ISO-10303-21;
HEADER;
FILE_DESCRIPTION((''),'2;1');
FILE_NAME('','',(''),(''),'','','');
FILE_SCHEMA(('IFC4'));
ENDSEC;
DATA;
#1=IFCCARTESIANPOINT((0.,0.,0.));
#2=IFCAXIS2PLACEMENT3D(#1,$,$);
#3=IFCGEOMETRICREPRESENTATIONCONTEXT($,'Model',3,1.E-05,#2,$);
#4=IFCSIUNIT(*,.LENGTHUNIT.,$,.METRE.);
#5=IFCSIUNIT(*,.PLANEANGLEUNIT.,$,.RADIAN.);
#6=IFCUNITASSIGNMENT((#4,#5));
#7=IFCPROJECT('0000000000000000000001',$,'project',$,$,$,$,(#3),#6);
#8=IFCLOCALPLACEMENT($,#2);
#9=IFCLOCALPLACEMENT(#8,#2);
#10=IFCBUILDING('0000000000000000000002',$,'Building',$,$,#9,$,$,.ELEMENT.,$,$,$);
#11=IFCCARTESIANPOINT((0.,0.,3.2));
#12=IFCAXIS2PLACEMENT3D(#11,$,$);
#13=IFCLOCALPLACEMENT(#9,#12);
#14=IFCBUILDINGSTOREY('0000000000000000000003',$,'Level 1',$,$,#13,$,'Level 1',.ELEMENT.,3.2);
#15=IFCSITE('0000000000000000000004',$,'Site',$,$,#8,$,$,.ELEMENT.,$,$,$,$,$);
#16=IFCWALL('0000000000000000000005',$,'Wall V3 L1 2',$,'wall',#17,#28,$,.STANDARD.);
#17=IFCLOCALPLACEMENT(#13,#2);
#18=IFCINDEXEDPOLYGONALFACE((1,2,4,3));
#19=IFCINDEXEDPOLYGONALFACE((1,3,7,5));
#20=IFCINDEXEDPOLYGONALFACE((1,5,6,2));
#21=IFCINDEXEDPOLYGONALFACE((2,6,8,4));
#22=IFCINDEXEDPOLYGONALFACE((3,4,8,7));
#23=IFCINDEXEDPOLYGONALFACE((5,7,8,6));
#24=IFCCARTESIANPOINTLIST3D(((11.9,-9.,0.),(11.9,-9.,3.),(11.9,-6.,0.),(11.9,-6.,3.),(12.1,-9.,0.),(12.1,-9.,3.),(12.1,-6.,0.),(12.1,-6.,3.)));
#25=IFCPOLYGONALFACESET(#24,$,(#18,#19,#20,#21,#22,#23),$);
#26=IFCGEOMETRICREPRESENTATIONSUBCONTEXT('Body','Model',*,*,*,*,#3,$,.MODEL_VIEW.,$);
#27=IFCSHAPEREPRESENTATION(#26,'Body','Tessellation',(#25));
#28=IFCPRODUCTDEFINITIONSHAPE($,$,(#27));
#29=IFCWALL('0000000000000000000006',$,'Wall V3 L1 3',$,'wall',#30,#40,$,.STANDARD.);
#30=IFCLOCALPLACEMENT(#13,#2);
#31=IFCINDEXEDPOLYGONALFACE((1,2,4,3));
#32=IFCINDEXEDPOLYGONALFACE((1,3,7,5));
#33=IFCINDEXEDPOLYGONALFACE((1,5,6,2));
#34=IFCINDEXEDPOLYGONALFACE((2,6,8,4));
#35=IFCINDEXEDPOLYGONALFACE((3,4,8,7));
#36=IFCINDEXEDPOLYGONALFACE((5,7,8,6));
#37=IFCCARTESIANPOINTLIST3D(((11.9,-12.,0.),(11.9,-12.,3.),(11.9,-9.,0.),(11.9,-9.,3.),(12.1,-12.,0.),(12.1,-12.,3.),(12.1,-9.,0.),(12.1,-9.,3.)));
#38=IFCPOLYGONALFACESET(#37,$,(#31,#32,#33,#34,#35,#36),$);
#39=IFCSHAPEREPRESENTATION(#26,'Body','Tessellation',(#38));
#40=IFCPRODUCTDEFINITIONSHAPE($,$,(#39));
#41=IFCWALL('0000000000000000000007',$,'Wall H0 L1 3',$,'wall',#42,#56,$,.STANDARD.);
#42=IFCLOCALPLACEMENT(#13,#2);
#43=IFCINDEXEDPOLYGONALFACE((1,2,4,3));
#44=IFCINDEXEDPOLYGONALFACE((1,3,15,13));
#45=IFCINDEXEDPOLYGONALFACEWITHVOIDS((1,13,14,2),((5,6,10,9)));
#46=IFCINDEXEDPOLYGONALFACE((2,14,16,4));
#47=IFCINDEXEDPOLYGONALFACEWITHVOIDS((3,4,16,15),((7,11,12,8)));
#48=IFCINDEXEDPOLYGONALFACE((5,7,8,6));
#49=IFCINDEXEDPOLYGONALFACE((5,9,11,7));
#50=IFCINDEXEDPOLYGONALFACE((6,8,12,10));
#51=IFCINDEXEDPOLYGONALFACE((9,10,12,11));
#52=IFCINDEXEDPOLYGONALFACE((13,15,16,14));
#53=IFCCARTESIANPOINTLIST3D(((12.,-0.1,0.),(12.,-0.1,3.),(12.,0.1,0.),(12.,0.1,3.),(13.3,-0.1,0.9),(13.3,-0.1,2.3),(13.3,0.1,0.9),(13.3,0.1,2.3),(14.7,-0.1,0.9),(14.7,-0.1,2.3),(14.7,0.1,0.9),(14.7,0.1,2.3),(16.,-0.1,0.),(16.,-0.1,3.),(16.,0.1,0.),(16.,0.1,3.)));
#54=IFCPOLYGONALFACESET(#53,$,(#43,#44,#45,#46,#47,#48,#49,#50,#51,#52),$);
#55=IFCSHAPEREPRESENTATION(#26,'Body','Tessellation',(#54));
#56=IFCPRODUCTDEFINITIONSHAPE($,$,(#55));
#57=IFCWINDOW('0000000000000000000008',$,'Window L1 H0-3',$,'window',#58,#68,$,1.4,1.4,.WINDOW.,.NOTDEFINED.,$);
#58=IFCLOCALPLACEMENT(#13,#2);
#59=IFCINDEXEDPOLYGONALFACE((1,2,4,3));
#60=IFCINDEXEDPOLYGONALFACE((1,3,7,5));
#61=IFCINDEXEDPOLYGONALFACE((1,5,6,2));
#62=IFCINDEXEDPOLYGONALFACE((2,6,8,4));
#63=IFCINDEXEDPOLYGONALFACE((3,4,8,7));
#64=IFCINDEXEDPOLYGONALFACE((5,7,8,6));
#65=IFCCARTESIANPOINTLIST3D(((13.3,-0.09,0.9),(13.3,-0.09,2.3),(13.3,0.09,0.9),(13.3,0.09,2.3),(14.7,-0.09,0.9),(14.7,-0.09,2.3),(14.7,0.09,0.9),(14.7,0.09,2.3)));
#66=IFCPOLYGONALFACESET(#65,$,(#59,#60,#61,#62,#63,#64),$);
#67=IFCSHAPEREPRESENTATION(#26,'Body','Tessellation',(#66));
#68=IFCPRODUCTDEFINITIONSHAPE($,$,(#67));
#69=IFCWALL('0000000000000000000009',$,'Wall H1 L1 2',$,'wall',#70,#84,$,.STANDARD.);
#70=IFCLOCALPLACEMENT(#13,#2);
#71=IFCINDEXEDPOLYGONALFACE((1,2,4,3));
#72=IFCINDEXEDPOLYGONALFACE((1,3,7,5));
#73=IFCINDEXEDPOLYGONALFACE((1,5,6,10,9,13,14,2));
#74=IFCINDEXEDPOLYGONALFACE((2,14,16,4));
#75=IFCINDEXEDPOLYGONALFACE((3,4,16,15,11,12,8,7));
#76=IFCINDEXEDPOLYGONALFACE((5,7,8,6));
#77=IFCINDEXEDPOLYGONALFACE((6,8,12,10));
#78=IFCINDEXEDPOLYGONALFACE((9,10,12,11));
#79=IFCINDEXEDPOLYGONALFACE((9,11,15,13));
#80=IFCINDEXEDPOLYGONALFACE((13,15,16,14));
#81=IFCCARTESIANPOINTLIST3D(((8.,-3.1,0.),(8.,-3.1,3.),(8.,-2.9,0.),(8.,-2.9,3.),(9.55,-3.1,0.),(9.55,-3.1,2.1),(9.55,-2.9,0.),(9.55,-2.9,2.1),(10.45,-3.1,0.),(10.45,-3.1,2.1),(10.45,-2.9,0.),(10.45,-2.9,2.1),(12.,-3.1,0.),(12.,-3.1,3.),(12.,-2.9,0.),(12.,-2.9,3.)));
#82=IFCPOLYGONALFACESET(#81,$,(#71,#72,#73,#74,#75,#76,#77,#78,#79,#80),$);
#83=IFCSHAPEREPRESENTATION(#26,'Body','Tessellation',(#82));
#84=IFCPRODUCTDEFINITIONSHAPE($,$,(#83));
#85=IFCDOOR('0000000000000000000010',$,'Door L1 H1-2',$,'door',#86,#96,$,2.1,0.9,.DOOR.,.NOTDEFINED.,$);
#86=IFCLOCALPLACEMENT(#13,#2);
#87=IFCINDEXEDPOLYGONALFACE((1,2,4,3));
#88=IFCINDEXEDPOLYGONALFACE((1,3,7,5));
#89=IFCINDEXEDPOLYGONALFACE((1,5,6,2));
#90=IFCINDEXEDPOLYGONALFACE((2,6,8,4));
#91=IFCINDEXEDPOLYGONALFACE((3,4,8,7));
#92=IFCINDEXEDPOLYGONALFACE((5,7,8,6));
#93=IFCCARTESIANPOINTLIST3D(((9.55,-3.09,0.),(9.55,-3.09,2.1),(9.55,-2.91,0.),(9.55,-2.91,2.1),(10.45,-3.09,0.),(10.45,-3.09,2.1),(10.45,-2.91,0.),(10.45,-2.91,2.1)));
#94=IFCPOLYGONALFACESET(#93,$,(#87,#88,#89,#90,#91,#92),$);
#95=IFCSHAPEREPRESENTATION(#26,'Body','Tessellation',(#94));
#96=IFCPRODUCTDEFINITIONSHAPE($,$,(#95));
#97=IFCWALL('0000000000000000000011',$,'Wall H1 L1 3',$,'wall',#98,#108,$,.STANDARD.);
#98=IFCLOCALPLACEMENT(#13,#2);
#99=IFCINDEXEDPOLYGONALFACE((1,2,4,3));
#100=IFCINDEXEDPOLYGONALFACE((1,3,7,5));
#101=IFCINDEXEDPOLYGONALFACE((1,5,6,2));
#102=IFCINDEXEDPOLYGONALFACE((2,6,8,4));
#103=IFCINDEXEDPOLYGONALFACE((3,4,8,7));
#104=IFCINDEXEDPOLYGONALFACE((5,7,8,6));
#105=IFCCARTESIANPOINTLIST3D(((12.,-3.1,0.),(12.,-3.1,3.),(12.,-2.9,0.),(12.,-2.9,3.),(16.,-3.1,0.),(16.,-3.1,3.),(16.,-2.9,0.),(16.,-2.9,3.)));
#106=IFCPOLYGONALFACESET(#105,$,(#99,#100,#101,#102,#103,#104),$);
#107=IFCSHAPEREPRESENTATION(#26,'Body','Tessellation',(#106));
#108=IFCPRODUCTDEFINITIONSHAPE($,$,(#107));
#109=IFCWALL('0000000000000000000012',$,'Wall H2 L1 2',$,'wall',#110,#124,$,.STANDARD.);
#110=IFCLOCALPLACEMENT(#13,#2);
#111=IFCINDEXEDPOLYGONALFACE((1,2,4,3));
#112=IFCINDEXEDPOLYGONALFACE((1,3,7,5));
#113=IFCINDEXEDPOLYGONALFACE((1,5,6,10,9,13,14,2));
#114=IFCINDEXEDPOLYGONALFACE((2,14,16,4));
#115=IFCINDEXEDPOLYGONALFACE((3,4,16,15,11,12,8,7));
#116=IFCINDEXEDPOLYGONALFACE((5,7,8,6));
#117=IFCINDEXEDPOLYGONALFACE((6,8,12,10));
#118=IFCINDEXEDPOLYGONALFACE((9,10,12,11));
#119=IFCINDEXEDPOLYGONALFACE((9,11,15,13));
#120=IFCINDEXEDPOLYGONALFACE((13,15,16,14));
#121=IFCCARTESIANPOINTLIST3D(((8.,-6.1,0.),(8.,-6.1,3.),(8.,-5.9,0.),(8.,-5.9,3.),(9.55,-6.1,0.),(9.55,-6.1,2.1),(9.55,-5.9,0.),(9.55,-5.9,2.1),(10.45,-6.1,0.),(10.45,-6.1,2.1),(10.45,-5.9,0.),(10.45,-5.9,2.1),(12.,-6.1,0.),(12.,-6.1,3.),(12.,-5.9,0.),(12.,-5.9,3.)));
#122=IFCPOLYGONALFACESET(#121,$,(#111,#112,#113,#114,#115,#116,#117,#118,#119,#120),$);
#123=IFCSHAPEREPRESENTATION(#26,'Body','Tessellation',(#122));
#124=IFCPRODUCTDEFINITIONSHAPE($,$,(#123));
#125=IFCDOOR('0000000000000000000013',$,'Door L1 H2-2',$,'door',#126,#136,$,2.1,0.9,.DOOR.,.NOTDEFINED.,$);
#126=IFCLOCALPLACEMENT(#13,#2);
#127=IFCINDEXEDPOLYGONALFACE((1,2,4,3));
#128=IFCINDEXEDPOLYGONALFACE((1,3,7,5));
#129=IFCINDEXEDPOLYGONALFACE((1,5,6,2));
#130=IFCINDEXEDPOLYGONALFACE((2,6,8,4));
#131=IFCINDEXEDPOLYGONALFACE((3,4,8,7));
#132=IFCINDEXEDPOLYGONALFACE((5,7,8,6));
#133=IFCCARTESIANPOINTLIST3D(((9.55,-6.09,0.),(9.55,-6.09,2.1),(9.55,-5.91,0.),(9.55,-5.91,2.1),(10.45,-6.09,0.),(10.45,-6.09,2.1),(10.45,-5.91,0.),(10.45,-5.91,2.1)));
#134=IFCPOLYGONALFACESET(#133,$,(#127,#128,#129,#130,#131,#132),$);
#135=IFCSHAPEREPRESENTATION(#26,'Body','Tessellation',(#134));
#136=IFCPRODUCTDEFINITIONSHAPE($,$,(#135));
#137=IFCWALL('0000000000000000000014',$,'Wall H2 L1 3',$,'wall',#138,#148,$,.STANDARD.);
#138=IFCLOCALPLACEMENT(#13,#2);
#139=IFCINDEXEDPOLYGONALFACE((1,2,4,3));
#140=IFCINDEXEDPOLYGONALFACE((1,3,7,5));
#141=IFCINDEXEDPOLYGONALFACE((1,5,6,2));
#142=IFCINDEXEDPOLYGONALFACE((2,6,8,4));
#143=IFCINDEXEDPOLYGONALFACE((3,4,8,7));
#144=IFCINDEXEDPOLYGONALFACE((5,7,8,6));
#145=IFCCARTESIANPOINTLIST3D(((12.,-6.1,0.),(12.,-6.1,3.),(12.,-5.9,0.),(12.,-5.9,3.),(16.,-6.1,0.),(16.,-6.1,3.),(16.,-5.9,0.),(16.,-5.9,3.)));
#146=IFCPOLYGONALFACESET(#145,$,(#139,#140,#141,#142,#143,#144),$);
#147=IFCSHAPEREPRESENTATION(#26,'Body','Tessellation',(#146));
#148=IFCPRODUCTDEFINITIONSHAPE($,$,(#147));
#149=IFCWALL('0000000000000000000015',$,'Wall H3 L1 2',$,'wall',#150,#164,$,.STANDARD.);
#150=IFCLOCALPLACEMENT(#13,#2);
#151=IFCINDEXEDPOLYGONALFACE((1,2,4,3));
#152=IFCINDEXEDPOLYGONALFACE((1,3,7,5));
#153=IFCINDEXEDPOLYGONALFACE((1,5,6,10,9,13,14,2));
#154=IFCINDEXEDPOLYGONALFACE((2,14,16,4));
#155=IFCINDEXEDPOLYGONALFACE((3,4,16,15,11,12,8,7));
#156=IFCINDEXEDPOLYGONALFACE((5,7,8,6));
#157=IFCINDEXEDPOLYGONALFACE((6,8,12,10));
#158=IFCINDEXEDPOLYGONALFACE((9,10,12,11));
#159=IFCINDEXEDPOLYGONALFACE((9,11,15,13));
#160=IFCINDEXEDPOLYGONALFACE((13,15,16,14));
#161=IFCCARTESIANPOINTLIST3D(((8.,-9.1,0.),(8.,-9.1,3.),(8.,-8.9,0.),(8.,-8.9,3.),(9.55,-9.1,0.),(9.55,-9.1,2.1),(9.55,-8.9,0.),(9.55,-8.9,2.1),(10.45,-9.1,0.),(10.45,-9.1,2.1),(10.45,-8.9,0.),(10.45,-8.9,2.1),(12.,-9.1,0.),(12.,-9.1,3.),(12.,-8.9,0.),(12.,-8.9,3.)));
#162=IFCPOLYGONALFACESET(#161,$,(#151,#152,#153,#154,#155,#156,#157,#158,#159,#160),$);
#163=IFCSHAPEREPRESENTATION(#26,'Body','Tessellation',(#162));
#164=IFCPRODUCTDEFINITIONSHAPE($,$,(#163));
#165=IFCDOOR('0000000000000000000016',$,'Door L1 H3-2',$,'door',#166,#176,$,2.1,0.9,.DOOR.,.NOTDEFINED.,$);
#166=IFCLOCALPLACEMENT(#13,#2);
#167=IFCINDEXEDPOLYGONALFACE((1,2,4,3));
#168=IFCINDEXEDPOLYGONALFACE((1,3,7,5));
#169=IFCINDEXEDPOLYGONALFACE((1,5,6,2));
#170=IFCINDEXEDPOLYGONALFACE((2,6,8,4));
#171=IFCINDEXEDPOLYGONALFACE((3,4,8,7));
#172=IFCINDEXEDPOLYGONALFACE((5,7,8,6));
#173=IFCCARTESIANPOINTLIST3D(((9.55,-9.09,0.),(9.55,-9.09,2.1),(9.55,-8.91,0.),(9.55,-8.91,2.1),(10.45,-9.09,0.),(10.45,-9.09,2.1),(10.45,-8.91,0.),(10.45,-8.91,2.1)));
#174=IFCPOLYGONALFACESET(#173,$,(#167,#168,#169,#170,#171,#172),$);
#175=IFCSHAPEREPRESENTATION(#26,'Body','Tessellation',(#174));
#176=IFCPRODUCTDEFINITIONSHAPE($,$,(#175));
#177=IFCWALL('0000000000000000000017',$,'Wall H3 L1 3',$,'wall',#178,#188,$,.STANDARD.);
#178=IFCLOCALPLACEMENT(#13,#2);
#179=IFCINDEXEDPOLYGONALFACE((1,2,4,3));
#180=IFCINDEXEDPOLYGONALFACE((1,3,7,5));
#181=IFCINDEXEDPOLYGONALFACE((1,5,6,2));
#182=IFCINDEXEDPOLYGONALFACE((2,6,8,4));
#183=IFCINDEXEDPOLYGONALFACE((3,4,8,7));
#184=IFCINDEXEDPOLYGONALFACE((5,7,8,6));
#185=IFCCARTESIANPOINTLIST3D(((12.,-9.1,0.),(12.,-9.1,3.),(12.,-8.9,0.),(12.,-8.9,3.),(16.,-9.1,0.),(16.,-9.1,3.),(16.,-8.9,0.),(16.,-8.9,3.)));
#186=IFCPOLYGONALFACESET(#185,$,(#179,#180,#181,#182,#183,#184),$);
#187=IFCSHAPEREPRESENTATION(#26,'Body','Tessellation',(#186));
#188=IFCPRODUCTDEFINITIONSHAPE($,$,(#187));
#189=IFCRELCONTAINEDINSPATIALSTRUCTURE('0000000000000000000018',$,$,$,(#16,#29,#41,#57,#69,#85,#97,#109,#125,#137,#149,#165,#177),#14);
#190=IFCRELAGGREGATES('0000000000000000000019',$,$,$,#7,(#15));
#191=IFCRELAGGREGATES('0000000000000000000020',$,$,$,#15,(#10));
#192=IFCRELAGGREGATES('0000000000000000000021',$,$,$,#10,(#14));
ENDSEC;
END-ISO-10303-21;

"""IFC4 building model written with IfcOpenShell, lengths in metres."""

from ifc_helpers import new_model, si_unit, frame, frame_2d, origin, origin_2d, place, context, subcontext, project, spatial, rectangle, extrude, element, fill, save


model = new_model("IFC4")

# Units and contexts
model_context = context("Model", 3, precision=1e-05, world=origin())
body_context = subcontext(model_context, "Body", "Model", "MODEL_VIEW")
ifc_project = project(units=[si_unit("LENGTHUNIT", "METRE"), si_unit("PLANEANGLEUNIT", "RADIAN")], contexts=[model_context])

# Site, building, storey
site_placement = place(None, origin())
site = spatial("IfcSite", under=ifc_project, at=site_placement, Name="Site", CompositionType="ELEMENT")
building_placement = place(site_placement, origin())
building = spatial("IfcBuilding", under=site, at=building_placement, Name="Building", CompositionType="ELEMENT")
storey_placement = place(building_placement, frame((0.0, 0.0, 3.2)))
storey = spatial("IfcBuildingStorey", under=building, at=storey_placement, Name="Level 1", LongName="Level 1", CompositionType="ELEMENT", Elevation=3.2)

# Walls
for number, where, z_axis, x_axis, name in (
    (1, (12.0, -6.0, 0.0), (0.0, 0.0, 1.0), (0.0, -1.0, 0.0), "Wall V3 L1 2"),
    (2, (12.0, -9.0, 0.0), (0.0, 0.0, 1.0), (0.0, -1.0, 0.0), "Wall V3 L1 3"),
):
    element("IfcWall", number, at=place(storey_placement, frame(where, z_axis=z_axis, x_axis=x_axis)), inside=storey, Name=name, ObjectType="wall", PredefinedType="STANDARD", context=body_context, shape_type="SweptSolid", body=[
        extrude(rectangle(XDim=3.0, YDim=0.2, at=frame_2d((1.5, 0.0))), origin(), (0.0, 0.0, 1.0), 3.0),
    ])

# Wall, opening, window
wall_1_placement = place(storey_placement, frame((12.0, 0.0, 0.0), z_axis=(0.0, 0.0, 1.0), x_axis=(1.0, 0.0, 0.0)))
wall_1 = element("IfcWall", 3, at=wall_1_placement, inside=storey, Name="Wall H0 L1 3", ObjectType="wall", PredefinedType="STANDARD", context=body_context, shape_type="SweptSolid", body=[
    extrude(rectangle(XDim=4.0, YDim=0.2, at=frame_2d((2.0, 0.0))), origin(), (0.0, 0.0, 1.0), 3.0),
])
opening_1_placement = place(storey_placement, frame((14.0, 0.0, 0.9), z_axis=(0.0, 0.0, 1.0), x_axis=(1.0, 0.0, 0.0)))
opening_1 = element("IfcOpeningElement", 4, at=opening_1_placement, cuts=wall_1, ObjectType="Opening", PredefinedType="OPENING", context=body_context, shape_type="SweptSolid", body=[
    extrude(rectangle(XDim=1.4, YDim=0.22, at=origin_2d()), origin(), (0.0, 0.0, 1.0), 1.4),
])
window_1_placement = place(storey_placement, frame((14.0, 0.0, 0.9), z_axis=(0.0, 0.0, 1.0), x_axis=(1.0, 0.0, 0.0)))
window_1 = element("IfcWindow", 5, at=window_1_placement, inside=storey, Name="Window L1 H0-3", ObjectType="window", OverallHeight=1.4, OverallWidth=1.4, PartitioningType="NOTDEFINED", PredefinedType="WINDOW", context=body_context, shape_type="SweptSolid", body=[
    extrude(rectangle(XDim=1.4, YDim=0.18, at=origin_2d()), origin(), (0.0, 0.0, 1.0), 1.4),
])
fill(opening_1, window_1)

# Wall, opening, door
wall_2_placement = place(storey_placement, frame((8.0, -3.0, 0.0), z_axis=(0.0, 0.0, 1.0), x_axis=(1.0, 0.0, 0.0)))
wall_2 = element("IfcWall", 6, at=wall_2_placement, inside=storey, Name="Wall H1 L1 2", ObjectType="wall", PredefinedType="STANDARD", context=body_context, shape_type="SweptSolid", body=[
    extrude(rectangle(XDim=4.0, YDim=0.2, at=frame_2d((2.0, 0.0))), origin(), (0.0, 0.0, 1.0), 3.0),
])
opening_2_placement = place(storey_placement, frame((10.0, -3.0, 0.0), z_axis=(0.0, 0.0, 1.0), x_axis=(1.0, 0.0, 0.0)))
opening_2 = element("IfcOpeningElement", 7, at=opening_2_placement, cuts=wall_2, ObjectType="Opening", PredefinedType="OPENING", context=body_context, shape_type="SweptSolid", body=[
    extrude(rectangle(XDim=0.9, YDim=0.22, at=origin_2d()), origin(), (0.0, 0.0, 1.0), 2.1),
])
door_1_placement = place(storey_placement, frame((10.0, -3.0, 0.0), z_axis=(0.0, 0.0, 1.0), x_axis=(1.0, 0.0, 0.0)))
door_1 = element("IfcDoor", 8, at=door_1_placement, inside=storey, Name="Door L1 H1-2", ObjectType="door", OperationType="NOTDEFINED", OverallHeight=2.1, OverallWidth=0.9, PredefinedType="DOOR", context=body_context, shape_type="SweptSolid", body=[
    extrude(rectangle(XDim=0.9, YDim=0.18, at=origin_2d()), origin(), (0.0, 0.0, 1.0), 2.1),
])
fill(opening_2, door_1)

# Wall
wall_3_placement = place(storey_placement, frame((12.0, -3.0, 0.0), z_axis=(0.0, 0.0, 1.0), x_axis=(1.0, 0.0, 0.0)))
element("IfcWall", 9, at=wall_3_placement, inside=storey, Name="Wall H1 L1 3", ObjectType="wall", PredefinedType="STANDARD", context=body_context, shape_type="SweptSolid", body=[
    extrude(rectangle(XDim=4.0, YDim=0.2, at=frame_2d((2.0, 0.0))), origin(), (0.0, 0.0, 1.0), 3.0),
])

# Wall, opening, door
wall_4_placement = place(storey_placement, frame((8.0, -6.0, 0.0), z_axis=(0.0, 0.0, 1.0), x_axis=(1.0, 0.0, 0.0)))
wall_4 = element("IfcWall", 10, at=wall_4_placement, inside=storey, Name="Wall H2 L1 2", ObjectType="wall", PredefinedType="STANDARD", context=body_context, shape_type="SweptSolid", body=[
    extrude(rectangle(XDim=4.0, YDim=0.2, at=frame_2d((2.0, 0.0))), origin(), (0.0, 0.0, 1.0), 3.0),
])
opening_3_placement = place(storey_placement, frame((10.0, -6.0, 0.0), z_axis=(0.0, 0.0, 1.0), x_axis=(1.0, 0.0, 0.0)))
opening_3 = element("IfcOpeningElement", 11, at=opening_3_placement, cuts=wall_4, ObjectType="Opening", PredefinedType="OPENING", context=body_context, shape_type="SweptSolid", body=[
    extrude(rectangle(XDim=0.9, YDim=0.22, at=origin_2d()), origin(), (0.0, 0.0, 1.0), 2.1),
])
door_2_placement = place(storey_placement, frame((10.0, -6.0, 0.0), z_axis=(0.0, 0.0, 1.0), x_axis=(1.0, 0.0, 0.0)))
door_2 = element("IfcDoor", 12, at=door_2_placement, inside=storey, Name="Door L1 H2-2", ObjectType="door", OperationType="NOTDEFINED", OverallHeight=2.1, OverallWidth=0.9, PredefinedType="DOOR", context=body_context, shape_type="SweptSolid", body=[
    extrude(rectangle(XDim=0.9, YDim=0.18, at=origin_2d()), origin(), (0.0, 0.0, 1.0), 2.1),
])
fill(opening_3, door_2)

# Wall
wall_5_placement = place(storey_placement, frame((12.0, -6.0, 0.0), z_axis=(0.0, 0.0, 1.0), x_axis=(1.0, 0.0, 0.0)))
element("IfcWall", 13, at=wall_5_placement, inside=storey, Name="Wall H2 L1 3", ObjectType="wall", PredefinedType="STANDARD", context=body_context, shape_type="SweptSolid", body=[
    extrude(rectangle(XDim=4.0, YDim=0.2, at=frame_2d((2.0, 0.0))), origin(), (0.0, 0.0, 1.0), 3.0),
])

# Wall, opening, door
wall_6_placement = place(storey_placement, frame((8.0, -9.0, 0.0), z_axis=(0.0, 0.0, 1.0), x_axis=(1.0, 0.0, 0.0)))
wall_6 = element("IfcWall", 14, at=wall_6_placement, inside=storey, Name="Wall H3 L1 2", ObjectType="wall", PredefinedType="STANDARD", context=body_context, shape_type="SweptSolid", body=[
    extrude(rectangle(XDim=4.0, YDim=0.2, at=frame_2d((2.0, 0.0))), origin(), (0.0, 0.0, 1.0), 3.0),
])
opening_4_placement = place(storey_placement, frame((10.0, -9.0, 0.0), z_axis=(0.0, 0.0, 1.0), x_axis=(1.0, 0.0, 0.0)))
opening_4 = element("IfcOpeningElement", 15, at=opening_4_placement, cuts=wall_6, ObjectType="Opening", PredefinedType="OPENING", context=body_context, shape_type="SweptSolid", body=[
    extrude(rectangle(XDim=0.9, YDim=0.22, at=origin_2d()), origin(), (0.0, 0.0, 1.0), 2.1),
])
door_3_placement = place(storey_placement, frame((10.0, -9.0, 0.0), z_axis=(0.0, 0.0, 1.0), x_axis=(1.0, 0.0, 0.0)))
door_3 = element("IfcDoor", 16, at=door_3_placement, inside=storey, Name="Door L1 H3-2", ObjectType="door", OperationType="NOTDEFINED", OverallHeight=2.1, OverallWidth=0.9, PredefinedType="DOOR", context=body_context, shape_type="SweptSolid", body=[
    extrude(rectangle(XDim=0.9, YDim=0.18, at=origin_2d()), origin(), (0.0, 0.0, 1.0), 2.1),
])
fill(opening_4, door_3)

# Wall
for number, where, z_axis, x_axis, name in (
    (17, (12.0, -9.0, 0.0), (0.0, 0.0, 1.0), (1.0, 0.0, 0.0), "Wall H3 L1 3"),
):
    element("IfcWall", number, at=place(storey_placement, frame(where, z_axis=z_axis, x_axis=x_axis)), inside=storey, Name=name, ObjectType="wall", PredefinedType="STANDARD", context=body_context, shape_type="SweptSolid", body=[
        extrude(rectangle(XDim=4.0, YDim=0.2, at=frame_2d((2.0, 0.0))), origin(), (0.0, 0.0, 1.0), 3.0),
    ])

save(model, "model.ifc")
